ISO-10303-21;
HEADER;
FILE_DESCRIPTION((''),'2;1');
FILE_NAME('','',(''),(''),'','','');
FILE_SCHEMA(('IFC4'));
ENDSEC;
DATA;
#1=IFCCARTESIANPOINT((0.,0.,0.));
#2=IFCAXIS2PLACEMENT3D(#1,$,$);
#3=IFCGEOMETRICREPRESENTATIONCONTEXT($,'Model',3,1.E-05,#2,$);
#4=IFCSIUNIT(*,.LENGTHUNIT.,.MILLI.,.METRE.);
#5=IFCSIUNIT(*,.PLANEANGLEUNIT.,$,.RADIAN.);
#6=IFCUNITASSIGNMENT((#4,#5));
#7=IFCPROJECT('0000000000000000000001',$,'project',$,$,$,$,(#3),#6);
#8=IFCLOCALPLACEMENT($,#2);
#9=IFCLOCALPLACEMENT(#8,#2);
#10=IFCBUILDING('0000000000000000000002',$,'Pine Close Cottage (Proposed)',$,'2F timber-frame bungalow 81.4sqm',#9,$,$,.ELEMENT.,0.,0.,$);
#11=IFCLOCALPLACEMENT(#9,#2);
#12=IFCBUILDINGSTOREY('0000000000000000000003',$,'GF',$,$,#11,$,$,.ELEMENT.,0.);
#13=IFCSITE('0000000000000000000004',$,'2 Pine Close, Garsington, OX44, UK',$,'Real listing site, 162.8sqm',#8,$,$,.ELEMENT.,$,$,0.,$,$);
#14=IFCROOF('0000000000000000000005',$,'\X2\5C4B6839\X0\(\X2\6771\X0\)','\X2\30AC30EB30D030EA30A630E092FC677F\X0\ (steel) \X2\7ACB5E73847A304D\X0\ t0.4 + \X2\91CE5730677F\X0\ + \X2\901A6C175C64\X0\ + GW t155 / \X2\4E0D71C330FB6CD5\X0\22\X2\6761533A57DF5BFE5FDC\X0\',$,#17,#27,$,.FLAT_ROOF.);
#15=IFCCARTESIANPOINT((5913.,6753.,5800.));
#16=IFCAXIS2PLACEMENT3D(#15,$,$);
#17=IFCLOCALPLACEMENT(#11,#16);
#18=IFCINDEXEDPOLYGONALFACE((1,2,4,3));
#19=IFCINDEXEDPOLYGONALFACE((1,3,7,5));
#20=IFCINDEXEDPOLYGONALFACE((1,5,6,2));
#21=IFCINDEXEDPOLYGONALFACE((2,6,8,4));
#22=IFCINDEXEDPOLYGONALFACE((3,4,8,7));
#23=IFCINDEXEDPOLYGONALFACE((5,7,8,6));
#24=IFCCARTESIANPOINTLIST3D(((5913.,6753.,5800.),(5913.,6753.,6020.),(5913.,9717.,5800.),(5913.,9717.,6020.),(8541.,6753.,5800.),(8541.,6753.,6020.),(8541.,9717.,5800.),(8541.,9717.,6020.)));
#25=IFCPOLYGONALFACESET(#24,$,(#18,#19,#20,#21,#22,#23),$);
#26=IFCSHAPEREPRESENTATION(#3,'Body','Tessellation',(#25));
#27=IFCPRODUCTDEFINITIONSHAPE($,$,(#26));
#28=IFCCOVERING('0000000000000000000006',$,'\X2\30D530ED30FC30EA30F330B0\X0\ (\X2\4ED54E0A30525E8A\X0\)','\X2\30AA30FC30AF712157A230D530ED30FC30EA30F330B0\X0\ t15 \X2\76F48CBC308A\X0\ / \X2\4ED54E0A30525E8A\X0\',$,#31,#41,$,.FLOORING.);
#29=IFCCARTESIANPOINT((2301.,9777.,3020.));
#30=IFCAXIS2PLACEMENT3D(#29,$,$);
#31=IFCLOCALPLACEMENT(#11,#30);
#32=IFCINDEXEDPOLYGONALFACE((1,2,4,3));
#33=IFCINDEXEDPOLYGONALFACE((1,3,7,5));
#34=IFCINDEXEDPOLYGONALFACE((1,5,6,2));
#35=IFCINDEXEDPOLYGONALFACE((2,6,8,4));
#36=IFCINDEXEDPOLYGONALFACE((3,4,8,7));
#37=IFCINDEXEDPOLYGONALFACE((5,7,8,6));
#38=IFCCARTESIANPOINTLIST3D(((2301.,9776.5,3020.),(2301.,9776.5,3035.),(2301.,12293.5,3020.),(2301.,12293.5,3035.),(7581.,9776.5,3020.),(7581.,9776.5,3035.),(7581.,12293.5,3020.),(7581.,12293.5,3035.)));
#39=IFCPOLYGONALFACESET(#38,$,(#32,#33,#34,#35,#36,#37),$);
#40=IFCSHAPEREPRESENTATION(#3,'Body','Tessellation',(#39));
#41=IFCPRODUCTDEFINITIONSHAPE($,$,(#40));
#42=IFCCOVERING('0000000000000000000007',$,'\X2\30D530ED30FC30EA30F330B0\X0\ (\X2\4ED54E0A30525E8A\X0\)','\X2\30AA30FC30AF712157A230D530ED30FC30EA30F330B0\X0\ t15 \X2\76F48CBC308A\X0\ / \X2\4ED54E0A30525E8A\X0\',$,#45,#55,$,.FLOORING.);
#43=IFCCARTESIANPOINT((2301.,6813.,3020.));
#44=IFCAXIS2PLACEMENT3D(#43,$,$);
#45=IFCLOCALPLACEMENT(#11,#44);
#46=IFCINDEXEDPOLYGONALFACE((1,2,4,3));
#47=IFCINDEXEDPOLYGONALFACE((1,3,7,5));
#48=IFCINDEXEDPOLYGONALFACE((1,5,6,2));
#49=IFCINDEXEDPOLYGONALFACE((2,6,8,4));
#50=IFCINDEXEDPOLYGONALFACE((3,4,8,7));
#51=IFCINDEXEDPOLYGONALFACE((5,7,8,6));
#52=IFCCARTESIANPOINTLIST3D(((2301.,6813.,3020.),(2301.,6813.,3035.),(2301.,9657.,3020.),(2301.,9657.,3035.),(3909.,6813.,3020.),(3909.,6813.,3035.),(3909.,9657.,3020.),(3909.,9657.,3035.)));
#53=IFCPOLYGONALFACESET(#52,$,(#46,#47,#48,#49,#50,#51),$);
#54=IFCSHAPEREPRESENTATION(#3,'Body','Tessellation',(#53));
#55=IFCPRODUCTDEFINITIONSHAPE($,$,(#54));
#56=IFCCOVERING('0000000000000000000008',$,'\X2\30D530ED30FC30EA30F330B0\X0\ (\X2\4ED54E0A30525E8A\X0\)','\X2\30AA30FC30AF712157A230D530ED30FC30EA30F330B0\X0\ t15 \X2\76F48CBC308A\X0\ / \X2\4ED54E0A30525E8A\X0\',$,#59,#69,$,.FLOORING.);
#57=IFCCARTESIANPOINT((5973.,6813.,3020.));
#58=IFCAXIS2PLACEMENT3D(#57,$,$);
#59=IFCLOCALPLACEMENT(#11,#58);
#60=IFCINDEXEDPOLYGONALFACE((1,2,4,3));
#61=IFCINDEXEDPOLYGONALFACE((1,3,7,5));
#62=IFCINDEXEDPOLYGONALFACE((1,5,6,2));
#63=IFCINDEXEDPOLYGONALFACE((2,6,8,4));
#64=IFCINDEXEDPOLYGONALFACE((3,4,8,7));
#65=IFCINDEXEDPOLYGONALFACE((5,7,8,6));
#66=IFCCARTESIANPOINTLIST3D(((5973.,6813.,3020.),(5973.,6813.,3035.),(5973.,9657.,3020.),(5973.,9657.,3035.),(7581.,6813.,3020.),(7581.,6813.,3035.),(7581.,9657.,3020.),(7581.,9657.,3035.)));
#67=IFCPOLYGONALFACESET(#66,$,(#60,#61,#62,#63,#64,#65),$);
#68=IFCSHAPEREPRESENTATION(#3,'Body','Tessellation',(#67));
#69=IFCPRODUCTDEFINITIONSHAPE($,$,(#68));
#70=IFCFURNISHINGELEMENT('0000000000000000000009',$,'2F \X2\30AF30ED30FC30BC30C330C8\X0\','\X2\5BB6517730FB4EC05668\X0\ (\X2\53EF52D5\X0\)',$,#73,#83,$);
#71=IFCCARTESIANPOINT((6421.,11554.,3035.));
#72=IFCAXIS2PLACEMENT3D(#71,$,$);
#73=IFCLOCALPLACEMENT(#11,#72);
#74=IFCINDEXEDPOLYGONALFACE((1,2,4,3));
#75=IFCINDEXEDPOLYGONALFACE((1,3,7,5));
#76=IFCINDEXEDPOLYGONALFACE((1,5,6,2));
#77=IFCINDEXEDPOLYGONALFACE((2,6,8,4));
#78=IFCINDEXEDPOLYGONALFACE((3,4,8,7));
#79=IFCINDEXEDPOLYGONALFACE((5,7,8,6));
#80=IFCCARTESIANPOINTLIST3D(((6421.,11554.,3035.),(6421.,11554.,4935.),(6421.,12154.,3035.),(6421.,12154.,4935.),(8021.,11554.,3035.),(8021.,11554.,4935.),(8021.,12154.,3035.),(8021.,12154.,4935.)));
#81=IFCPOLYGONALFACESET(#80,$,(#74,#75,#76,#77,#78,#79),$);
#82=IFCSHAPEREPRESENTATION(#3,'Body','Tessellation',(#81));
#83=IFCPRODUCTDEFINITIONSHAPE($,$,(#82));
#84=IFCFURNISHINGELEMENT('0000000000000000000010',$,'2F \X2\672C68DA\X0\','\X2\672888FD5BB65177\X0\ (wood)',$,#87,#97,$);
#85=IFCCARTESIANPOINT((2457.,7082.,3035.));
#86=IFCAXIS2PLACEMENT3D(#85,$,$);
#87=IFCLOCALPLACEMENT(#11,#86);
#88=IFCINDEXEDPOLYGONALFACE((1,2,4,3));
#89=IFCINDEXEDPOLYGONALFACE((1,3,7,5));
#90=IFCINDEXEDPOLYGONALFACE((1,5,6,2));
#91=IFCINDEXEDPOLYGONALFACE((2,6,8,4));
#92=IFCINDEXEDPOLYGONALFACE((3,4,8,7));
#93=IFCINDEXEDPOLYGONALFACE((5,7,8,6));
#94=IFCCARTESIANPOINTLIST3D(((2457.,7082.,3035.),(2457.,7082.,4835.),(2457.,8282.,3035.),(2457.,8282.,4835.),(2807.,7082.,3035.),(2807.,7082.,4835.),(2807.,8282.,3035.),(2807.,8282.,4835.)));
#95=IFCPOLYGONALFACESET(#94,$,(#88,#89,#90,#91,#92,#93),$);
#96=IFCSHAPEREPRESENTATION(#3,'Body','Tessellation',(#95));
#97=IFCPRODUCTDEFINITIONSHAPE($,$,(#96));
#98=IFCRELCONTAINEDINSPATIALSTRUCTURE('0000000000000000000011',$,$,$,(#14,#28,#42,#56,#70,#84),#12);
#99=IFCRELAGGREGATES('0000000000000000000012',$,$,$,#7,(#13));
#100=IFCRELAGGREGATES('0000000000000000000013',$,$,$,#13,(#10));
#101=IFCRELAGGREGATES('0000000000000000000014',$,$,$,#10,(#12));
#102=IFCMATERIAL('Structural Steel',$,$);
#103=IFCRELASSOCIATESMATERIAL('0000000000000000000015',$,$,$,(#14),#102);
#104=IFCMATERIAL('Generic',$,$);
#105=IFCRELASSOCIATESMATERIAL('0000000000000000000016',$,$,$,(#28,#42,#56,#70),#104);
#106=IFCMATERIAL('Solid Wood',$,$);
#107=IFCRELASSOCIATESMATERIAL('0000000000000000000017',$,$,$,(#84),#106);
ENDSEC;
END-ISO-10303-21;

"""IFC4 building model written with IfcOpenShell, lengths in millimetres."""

from ifc_helpers import new_model, si_unit, frame, frame_2d, origin, place, context, project, spatial, rectangle, extrude, material, element, save


model = new_model("IFC4")

# Units and contexts
model_context = context("Model", 3, precision=1e-05, world=origin())
ifc_project = project(units=[si_unit("LENGTHUNIT", "METRE", prefix="MILLI"), si_unit("PLANEANGLEUNIT", "RADIAN")], contexts=[model_context])

# Site, building, storey
site_placement = place(None, origin())
site = spatial("IfcSite", under=ifc_project, at=site_placement, Name="2 Pine Close, Garsington, OX44, UK", ObjectType="Real listing site, 162.8sqm", CompositionType="ELEMENT", RefElevation=0.0)
building_placement = place(site_placement, origin())
building = spatial("IfcBuilding", under=site, at=building_placement, Name="Pine Close Cottage (Proposed)", ObjectType="2F timber-frame bungalow 81.4sqm", CompositionType="ELEMENT", ElevationOfRefHeight=0.0, ElevationOfTerrain=0.0)
storey_placement = place(building_placement, origin())
storey = spatial("IfcBuildingStorey", under=building, at=storey_placement, Name="GF", CompositionType="ELEMENT", Elevation=0.0)

# Shared definitions
ifc_material_1 = material(Name="Solid Wood")

# Roof
ifc_material_2 = material(Name="Structural Steel")
roof_1_placement = place(storey_placement, frame((5913.0, 6753.0, 5800.0)))
element("IfcRoof", 1, at=roof_1_placement, inside=storey, material=ifc_material_2, Name="屋根(東)", Description="ガルバリウム鋼板 (steel) 立平葺き t0.4 + 野地板 + 通気層 + GW t155 / 不燃・法22条区域対応", PredefinedType="FLAT_ROOF", context=model_context, shape_type="SweptSolid", body=[
    extrude(rectangle(XDim=2628.0, YDim=2964.0, at=frame_2d((1314.0, 1482.0))), frame((5913.0, 6753.0, 5800.0)), (0.0, 0.0, 1.0), 220.0),
])

# Coverings
ifc_material_3 = material(Name="Generic")
covering_1_placement = place(storey_placement, frame((2301.0, 9777.0, 3020.0)))
element("IfcCovering", 2, at=covering_1_placement, inside=storey, material=ifc_material_3, Name="フローリング (仕上げ床)", Description="オーク無垢フローリング t15 直貼り / 仕上げ床", PredefinedType="FLOORING", context=model_context, shape_type="SweptSolid", body=[
    extrude(rectangle(XDim=5280.0, YDim=2517.0, at=frame_2d((2640.0, 1258.0))), frame((2301.0, 9777.0, 3020.0)), (0.0, 0.0, 1.0), 15.0),
])
covering_2_placement = place(storey_placement, frame((2301.0, 6813.0, 3020.0)))
element("IfcCovering", 3, at=covering_2_placement, inside=storey, material=ifc_material_3, Name="フローリング (仕上げ床)", Description="オーク無垢フローリング t15 直貼り / 仕上げ床", PredefinedType="FLOORING", context=model_context, shape_type="SweptSolid", body=[
    extrude(rectangle(XDim=1608.0, YDim=2844.0, at=frame_2d((804.0, 1422.0))), frame((2301.0, 6813.0, 3020.0)), (0.0, 0.0, 1.0), 15.0),
])
covering_3_placement = place(storey_placement, frame((5973.0, 6813.0, 3020.0)))
element("IfcCovering", 4, at=covering_3_placement, inside=storey, material=ifc_material_3, Name="フローリング (仕上げ床)", Description="オーク無垢フローリング t15 直貼り / 仕上げ床", PredefinedType="FLOORING", context=model_context, shape_type="SweptSolid", body=[
    extrude(rectangle(XDim=1608.0, YDim=2844.0, at=frame_2d((804.0, 1422.0))), frame((5973.0, 6813.0, 3020.0)), (0.0, 0.0, 1.0), 15.0),
])

# Furnishing elements
furnishing_1_placement = place(storey_placement, frame((6421.0, 11554.0, 3035.0)))
element("IfcFurnishingElement", 5, at=furnishing_1_placement, inside=storey, material=ifc_material_3, Name="2F クローゼット", Description="家具・什器 (可動)", context=model_context, shape_type="SweptSolid", body=[
    extrude(rectangle(XDim=1600.0, YDim=600.0, at=frame_2d((800.0, 300.0))), frame((6421.0, 11554.0, 3035.0)), (0.0, 0.0, 1.0), 1900.0),
])
furnishing_2_placement = place(storey_placement, frame((2457.0, 7082.0, 3035.0)))
element("IfcFurnishingElement", 6, at=furnishing_2_placement, inside=storey, material=ifc_material_1, Name="2F 本棚", Description="木製家具 (wood)", context=model_context, shape_type="SweptSolid", body=[
    extrude(rectangle(XDim=350.0, YDim=1200.0, at=frame_2d((175.0, 600.0))), frame((2457.0, 7082.0, 3035.0)), (0.0, 0.0, 1.0), 1800.0),
])

save(model, "model.ifc")
